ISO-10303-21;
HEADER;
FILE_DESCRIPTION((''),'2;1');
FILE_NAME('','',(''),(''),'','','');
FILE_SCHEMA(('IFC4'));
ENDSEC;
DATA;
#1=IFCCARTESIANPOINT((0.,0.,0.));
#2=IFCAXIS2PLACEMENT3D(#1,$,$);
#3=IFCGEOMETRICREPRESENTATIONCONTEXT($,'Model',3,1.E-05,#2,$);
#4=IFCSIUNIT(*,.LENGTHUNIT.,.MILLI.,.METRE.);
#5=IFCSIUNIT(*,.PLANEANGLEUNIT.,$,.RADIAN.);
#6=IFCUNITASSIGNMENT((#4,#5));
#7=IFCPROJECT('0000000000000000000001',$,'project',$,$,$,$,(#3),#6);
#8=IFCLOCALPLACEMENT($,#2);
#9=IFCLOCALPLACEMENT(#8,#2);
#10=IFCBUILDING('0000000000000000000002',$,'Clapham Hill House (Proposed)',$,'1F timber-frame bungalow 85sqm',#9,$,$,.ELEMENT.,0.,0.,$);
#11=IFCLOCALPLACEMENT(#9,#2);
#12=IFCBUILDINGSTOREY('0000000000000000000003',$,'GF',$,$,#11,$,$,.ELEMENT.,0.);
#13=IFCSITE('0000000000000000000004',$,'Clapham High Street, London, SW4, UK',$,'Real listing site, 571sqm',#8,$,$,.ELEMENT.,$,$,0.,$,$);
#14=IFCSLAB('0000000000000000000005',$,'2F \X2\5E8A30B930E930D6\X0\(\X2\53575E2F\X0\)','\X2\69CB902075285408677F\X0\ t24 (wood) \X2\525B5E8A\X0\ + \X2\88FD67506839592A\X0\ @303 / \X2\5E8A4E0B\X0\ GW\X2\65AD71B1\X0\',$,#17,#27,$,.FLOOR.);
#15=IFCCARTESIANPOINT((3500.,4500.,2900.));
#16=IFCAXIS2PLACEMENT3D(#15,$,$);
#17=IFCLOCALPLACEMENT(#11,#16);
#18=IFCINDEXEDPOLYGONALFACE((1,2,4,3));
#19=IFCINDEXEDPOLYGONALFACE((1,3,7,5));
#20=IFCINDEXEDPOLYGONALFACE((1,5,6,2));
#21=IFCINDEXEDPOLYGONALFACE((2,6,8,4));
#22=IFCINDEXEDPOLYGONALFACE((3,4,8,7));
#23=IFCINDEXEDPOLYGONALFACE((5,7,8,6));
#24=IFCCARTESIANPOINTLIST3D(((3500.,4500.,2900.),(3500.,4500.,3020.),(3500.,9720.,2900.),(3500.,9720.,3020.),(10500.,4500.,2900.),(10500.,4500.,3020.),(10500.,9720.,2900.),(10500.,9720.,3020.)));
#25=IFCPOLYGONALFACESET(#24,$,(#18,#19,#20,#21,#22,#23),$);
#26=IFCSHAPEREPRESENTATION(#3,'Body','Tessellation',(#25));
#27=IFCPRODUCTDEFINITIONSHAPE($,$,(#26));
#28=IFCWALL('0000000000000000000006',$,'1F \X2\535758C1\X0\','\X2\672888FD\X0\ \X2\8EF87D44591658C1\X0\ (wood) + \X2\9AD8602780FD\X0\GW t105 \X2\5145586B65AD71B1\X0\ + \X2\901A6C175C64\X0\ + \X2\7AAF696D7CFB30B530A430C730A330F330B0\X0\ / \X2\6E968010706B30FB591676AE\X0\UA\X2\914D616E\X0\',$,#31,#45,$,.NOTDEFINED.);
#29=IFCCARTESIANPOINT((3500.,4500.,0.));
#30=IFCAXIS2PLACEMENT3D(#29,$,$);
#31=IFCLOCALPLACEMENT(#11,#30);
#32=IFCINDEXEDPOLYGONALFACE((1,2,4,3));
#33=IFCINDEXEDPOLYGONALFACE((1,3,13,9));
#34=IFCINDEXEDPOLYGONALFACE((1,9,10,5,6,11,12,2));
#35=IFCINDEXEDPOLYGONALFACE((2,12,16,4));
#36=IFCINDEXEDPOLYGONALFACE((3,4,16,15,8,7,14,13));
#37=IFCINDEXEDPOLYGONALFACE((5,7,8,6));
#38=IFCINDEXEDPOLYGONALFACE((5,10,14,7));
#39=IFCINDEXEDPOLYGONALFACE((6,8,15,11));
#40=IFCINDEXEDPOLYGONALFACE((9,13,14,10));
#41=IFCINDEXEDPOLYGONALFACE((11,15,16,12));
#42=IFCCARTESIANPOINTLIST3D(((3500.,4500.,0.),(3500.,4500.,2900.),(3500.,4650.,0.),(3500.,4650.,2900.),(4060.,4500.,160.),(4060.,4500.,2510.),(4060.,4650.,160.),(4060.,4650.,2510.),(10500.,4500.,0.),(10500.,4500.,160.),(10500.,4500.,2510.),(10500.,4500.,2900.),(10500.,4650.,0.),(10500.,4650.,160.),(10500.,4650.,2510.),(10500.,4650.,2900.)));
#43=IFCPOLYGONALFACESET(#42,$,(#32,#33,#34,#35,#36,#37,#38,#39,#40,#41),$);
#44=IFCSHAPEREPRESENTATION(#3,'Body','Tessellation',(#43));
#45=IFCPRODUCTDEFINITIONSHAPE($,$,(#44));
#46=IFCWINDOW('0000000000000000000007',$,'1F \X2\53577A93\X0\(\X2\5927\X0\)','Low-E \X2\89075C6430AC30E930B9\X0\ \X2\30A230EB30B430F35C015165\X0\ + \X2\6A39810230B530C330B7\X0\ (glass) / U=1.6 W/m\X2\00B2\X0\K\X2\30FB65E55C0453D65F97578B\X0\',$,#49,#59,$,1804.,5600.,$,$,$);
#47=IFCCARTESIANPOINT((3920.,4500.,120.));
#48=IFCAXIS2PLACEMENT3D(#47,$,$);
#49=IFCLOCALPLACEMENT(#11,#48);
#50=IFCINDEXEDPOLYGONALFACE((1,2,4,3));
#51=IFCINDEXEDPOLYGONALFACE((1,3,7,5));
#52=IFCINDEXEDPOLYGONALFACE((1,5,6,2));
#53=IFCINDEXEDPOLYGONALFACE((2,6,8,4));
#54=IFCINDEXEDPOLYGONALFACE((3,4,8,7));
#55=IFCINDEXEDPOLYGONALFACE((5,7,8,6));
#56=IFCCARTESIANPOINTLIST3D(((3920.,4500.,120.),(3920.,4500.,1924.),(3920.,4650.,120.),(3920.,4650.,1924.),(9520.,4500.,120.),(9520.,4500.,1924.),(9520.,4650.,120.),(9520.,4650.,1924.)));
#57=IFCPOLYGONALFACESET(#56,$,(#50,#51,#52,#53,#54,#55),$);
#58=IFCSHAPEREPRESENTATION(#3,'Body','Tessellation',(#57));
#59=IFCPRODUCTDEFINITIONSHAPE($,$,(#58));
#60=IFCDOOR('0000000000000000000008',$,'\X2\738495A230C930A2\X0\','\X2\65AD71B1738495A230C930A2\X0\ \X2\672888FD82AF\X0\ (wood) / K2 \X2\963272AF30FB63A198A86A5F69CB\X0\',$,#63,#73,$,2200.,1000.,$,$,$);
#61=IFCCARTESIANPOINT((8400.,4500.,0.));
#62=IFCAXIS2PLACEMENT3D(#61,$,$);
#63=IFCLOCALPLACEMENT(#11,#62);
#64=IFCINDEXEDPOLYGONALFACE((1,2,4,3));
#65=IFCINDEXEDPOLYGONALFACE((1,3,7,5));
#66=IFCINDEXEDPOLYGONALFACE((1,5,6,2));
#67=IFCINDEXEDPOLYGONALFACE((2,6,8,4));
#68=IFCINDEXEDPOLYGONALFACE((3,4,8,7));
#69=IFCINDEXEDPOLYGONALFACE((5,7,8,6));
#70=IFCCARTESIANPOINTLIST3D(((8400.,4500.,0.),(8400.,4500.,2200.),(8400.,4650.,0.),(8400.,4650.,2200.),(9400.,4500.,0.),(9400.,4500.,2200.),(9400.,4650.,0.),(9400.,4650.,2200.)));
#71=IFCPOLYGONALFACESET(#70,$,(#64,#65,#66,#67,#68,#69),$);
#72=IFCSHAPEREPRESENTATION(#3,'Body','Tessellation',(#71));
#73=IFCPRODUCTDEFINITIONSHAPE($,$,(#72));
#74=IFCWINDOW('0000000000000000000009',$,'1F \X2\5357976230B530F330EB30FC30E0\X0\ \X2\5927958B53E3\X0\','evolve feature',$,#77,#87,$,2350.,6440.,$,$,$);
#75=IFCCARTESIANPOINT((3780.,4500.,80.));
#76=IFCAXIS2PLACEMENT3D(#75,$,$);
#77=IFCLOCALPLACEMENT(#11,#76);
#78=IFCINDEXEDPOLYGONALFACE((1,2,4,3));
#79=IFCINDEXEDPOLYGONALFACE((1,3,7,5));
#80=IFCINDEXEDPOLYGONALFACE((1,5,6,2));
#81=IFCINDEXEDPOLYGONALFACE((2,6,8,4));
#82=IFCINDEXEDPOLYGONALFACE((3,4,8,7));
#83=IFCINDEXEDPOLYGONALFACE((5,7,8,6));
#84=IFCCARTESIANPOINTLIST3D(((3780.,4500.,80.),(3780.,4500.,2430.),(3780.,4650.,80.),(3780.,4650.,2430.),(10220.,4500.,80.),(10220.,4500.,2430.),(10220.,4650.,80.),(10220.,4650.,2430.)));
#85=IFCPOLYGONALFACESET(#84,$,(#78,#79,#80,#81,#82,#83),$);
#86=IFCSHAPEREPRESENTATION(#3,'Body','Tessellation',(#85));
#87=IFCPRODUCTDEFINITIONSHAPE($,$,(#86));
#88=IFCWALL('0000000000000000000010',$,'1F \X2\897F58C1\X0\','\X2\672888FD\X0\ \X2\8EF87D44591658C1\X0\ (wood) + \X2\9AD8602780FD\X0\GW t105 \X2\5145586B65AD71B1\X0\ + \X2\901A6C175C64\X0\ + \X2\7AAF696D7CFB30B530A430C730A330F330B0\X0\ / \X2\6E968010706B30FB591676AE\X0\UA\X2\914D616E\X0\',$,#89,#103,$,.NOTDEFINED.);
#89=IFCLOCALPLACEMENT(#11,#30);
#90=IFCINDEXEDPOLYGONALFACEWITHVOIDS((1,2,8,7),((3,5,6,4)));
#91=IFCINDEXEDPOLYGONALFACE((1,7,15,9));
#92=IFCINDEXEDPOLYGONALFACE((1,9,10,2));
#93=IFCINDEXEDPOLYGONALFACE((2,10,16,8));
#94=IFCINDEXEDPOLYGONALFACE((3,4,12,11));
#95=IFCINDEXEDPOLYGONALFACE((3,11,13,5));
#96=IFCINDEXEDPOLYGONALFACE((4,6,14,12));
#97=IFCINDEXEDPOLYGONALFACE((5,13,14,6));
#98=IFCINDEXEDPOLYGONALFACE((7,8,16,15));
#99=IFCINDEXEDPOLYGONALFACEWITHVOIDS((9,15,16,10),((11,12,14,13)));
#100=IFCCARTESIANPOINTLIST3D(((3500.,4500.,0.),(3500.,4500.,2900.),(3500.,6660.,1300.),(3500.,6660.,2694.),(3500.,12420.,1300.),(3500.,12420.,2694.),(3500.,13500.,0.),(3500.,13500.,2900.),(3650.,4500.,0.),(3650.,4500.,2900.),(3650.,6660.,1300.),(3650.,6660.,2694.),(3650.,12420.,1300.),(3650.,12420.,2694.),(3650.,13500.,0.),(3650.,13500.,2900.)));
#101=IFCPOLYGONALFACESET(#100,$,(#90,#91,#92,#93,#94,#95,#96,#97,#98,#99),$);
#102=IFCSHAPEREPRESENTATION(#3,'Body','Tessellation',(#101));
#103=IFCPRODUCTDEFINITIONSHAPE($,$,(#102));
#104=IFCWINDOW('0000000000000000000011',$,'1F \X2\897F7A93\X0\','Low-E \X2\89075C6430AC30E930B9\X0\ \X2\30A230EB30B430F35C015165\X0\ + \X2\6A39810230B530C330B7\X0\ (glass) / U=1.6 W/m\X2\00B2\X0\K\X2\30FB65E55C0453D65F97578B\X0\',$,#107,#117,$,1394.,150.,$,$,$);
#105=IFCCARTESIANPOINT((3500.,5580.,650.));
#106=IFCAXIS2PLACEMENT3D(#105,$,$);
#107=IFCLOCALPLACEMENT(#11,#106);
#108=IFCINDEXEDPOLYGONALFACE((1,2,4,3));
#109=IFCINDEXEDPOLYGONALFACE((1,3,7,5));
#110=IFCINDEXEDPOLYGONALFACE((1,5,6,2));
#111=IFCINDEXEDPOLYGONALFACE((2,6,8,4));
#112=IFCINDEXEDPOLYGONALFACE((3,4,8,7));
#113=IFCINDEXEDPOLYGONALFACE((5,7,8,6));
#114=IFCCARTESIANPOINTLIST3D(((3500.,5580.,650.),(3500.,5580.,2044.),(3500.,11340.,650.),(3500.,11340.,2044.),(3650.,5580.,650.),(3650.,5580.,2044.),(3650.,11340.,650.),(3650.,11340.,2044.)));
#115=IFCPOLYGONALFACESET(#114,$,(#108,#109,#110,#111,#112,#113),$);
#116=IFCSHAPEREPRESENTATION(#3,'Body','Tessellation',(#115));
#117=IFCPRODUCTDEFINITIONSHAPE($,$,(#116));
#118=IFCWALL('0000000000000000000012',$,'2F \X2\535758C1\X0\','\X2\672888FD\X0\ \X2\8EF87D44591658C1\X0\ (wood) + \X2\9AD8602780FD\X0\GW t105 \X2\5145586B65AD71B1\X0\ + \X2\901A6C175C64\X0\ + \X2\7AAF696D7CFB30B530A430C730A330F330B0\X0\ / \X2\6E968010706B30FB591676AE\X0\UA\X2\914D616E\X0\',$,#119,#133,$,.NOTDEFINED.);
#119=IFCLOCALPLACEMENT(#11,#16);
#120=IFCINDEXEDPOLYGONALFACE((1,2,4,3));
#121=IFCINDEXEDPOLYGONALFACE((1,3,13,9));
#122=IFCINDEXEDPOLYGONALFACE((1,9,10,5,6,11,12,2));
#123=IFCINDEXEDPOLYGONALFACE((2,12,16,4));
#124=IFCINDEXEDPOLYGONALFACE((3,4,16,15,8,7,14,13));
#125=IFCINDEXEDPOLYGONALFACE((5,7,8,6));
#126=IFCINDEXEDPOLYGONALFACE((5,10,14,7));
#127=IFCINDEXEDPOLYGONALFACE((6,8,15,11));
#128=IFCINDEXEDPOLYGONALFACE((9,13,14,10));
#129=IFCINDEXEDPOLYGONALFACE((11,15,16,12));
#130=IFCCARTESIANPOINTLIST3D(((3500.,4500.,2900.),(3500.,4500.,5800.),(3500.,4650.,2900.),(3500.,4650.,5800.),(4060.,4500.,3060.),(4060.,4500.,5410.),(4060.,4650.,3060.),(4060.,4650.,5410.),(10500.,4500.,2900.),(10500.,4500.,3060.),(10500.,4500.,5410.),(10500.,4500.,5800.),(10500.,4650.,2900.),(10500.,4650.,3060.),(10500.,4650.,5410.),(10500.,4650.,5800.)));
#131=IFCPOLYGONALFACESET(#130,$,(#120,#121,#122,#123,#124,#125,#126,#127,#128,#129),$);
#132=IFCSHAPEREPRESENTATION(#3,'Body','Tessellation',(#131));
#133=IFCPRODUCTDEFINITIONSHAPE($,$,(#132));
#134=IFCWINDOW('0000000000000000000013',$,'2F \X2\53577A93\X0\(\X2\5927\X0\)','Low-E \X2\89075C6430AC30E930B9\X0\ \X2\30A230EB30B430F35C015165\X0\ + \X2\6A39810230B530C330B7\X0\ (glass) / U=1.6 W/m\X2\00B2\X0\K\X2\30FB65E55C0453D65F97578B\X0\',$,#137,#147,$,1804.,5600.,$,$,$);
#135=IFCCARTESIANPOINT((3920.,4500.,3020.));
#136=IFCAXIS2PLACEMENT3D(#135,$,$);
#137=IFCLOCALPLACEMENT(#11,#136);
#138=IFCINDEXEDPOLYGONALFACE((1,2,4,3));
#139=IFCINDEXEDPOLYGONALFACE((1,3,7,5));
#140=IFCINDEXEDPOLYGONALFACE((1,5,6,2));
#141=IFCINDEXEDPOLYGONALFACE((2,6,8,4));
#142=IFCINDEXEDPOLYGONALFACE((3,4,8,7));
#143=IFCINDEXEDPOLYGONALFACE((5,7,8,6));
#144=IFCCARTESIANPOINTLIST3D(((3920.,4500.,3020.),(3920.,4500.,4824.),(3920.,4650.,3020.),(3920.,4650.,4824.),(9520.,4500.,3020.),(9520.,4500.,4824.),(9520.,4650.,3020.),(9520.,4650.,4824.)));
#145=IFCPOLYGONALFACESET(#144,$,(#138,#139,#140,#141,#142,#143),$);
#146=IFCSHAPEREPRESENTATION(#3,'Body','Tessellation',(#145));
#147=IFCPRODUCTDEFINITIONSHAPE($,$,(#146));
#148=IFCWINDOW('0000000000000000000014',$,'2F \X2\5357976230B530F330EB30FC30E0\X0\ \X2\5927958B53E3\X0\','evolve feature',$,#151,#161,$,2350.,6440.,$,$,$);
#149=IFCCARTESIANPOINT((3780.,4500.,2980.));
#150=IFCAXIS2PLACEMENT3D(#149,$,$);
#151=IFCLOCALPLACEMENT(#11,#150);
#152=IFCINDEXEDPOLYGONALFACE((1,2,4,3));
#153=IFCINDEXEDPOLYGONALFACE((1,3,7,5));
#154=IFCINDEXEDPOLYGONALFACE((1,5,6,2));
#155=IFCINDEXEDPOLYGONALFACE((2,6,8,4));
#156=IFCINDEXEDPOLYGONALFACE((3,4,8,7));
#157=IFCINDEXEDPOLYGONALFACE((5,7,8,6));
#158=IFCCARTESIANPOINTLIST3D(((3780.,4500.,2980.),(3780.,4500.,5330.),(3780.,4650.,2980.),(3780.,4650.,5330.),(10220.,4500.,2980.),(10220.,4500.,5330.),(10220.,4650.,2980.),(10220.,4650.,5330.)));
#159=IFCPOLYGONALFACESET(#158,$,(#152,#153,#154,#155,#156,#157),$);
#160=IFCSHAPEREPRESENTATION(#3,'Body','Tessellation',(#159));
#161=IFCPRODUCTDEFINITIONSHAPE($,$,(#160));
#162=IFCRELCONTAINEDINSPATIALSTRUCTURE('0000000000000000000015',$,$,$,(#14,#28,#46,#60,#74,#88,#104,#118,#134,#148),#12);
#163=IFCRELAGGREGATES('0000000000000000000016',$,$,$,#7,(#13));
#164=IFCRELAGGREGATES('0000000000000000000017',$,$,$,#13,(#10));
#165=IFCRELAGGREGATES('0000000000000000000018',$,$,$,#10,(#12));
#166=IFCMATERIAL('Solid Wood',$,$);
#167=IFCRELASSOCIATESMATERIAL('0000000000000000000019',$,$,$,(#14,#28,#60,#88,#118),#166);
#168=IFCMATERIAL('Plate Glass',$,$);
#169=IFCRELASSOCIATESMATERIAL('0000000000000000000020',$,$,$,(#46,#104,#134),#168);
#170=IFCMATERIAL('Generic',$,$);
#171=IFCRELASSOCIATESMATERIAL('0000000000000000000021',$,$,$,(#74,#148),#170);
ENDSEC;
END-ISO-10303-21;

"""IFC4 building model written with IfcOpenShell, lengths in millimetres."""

from ifc_helpers import new_model, si_unit, frame, frame_2d, origin, place, context, project, spatial, rectangle, extrude, material, element, fill, save


model = new_model("IFC4")

# Units and contexts
model_context = context("Model", 3, precision=1e-05, world=origin())
ifc_project = project(units=[si_unit("LENGTHUNIT", "METRE", prefix="MILLI"), si_unit("PLANEANGLEUNIT", "RADIAN")], contexts=[model_context])

# Site, building, storey
site_placement = place(None, origin())
site = spatial("IfcSite", under=ifc_project, at=site_placement, Name="Clapham High Street, London, SW4, UK", ObjectType="Real listing site, 571sqm", CompositionType="ELEMENT", RefElevation=0.0)
building_placement = place(site_placement, origin())
building = spatial("IfcBuilding", under=site, at=building_placement, Name="Clapham Hill House (Proposed)", ObjectType="1F timber-frame bungalow 85sqm", CompositionType="ELEMENT", ElevationOfRefHeight=0.0, ElevationOfTerrain=0.0)
storey_placement = place(building_placement, origin())
storey = spatial("IfcBuildingStorey", under=building, at=storey_placement, Name="GF", CompositionType="ELEMENT", Elevation=0.0)

# Slab
ifc_material_1 = material(Name="Solid Wood")
slab_1_placement = place(storey_placement, frame((3500.0, 4500.0, 2900.0)))
element("IfcSlab", 1, at=slab_1_placement, inside=storey, material=ifc_material_1, Name="2F 床スラブ(南帯)", Description="構造用合板 t24 (wood) 剛床 + 製材根太 @303 / 床下 GW断熱", PredefinedType="FLOOR", context=model_context, shape_type="SweptSolid", body=[
    extrude(rectangle(XDim=7000.0, YDim=5220.0, at=frame_2d((3500.0, 2610.0))), frame((3500.0, 4500.0, 2900.0)), (0.0, 0.0, 1.0), 120.0),
])
ifc_material_2 = material(Name="Generic")

# Wall, openings, windows, door
wall_1_placement = place(storey_placement, frame((3500.0, 4500.0, 0.0)))
wall_1 = element("IfcWall", 2, at=wall_1_placement, inside=storey, material=ifc_material_1, Name="1F 南壁", Description="木製 軸組外壁 (wood) + 高性能GW t105 充填断熱 + 通気層 + 窯業系サイディング / 準耐火・外皮UA配慮", PredefinedType="NOTDEFINED", context=model_context, shape_type="SweptSolid", body=[
    extrude(rectangle(XDim=7000.0, YDim=150.0, at=frame_2d((3500.0, 75.0))), frame((3500.0, 4500.0, 0.0)), (0.0, 0.0, 1.0), 2900.0),
])
opening_1_placement = place(storey_placement, frame((3920.0, 4500.0, 120.0)))
opening_1 = element("IfcOpeningElement", 3, at=opening_1_placement, cuts=wall_1, PredefinedType="NOTDEFINED", context=model_context, shape_type="SweptSolid", body=[
    extrude(rectangle(XDim=5600.0, YDim=150.0, at=frame_2d((2800.0, 75.0))), frame((3920.0, 4500.0, 120.0)), (0.0, 0.0, 1.0), 1804.0),
])
opening_2_placement = place(storey_placement, frame((8400.0, 4500.0, 0.0)))
opening_2 = element("IfcOpeningElement", 4, at=opening_2_placement, cuts=wall_1, PredefinedType="NOTDEFINED", context=model_context, shape_type="SweptSolid", body=[
    extrude(rectangle(XDim=1000.0, YDim=150.0, at=frame_2d((500.0, 75.0))), frame((8400.0, 4500.0, 0.0)), (0.0, 0.0, 1.0), 2200.0),
])
opening_3_placement = place(storey_placement, frame((3780.0, 4500.0, 80.0)))
opening_3 = element("IfcOpeningElement", 5, at=opening_3_placement, cuts=wall_1, PredefinedType="NOTDEFINED", context=model_context, shape_type="SweptSolid", body=[
    extrude(rectangle(XDim=6440.0, YDim=150.0, at=frame_2d((3220.0, 75.0))), frame((3780.0, 4500.0, 80.0)), (0.0, 0.0, 1.0), 2350.0),
])
ifc_material_3 = material(Name="Plate Glass")
window_1_placement = place(storey_placement, frame((3920.0, 4500.0, 120.0)))
window_1 = element("IfcWindow", 6, at=window_1_placement, inside=storey, material=ifc_material_3, Name="1F 南窓(大)", Description="Low-E 複層ガラス アルゴン封入 + 樹脂サッシ (glass) / U=1.6 W/m²K・日射取得型", OverallHeight=1804.0, OverallWidth=5600.0, context=model_context, shape_type="SweptSolid", body=[
    extrude(rectangle(XDim=5600.0, YDim=150.0, at=frame_2d((2800.0, 75.0))), frame((3920.0, 4500.0, 120.0)), (0.0, 0.0, 1.0), 1804.0),
])
fill(opening_1, window_1)
door_placement = place(storey_placement, frame((8400.0, 4500.0, 0.0)))
door = element("IfcDoor", 7, at=door_placement, inside=storey, material=ifc_material_1, Name="玄関ドア", Description="断熱玄関ドア 木製芯 (wood) / K2 防犯・採風機構", OverallHeight=2200.0, OverallWidth=1000.0, context=model_context, shape_type="SweptSolid", body=[
    extrude(rectangle(XDim=1000.0, YDim=150.0, at=frame_2d((500.0, 75.0))), frame((8400.0, 4500.0, 0.0)), (0.0, 0.0, 1.0), 2200.0),
])
fill(opening_2, door)
window_2_placement = place(storey_placement, frame((3780.0, 4500.0, 80.0)))
window_2 = element("IfcWindow", 8, at=window_2_placement, inside=storey, material=ifc_material_2, Name="1F 南面サンルーム 大開口", Description="evolve feature", OverallHeight=2350.0, OverallWidth=6440.0, context=model_context, shape_type="SweptSolid", body=[
    extrude(rectangle(XDim=6440.0, YDim=150.0, at=frame_2d((3220.0, 75.0))), frame((3780.0, 4500.0, 80.0)), (0.0, 0.0, 1.0), 2350.0),
])
fill(opening_3, window_2)

# Wall, opening, window
wall_2_placement = place(storey_placement, frame((3500.0, 4500.0, 0.0)))
wall_2 = element("IfcWall", 9, at=wall_2_placement, inside=storey, material=ifc_material_1, Name="1F 西壁", Description="木製 軸組外壁 (wood) + 高性能GW t105 充填断熱 + 通気層 + 窯業系サイディング / 準耐火・外皮UA配慮", PredefinedType="NOTDEFINED", context=model_context, shape_type="SweptSolid", body=[
    extrude(rectangle(XDim=150.0, YDim=9000.0, at=frame_2d((75.0, 4500.0))), frame((3500.0, 4500.0, 0.0)), (0.0, 0.0, 1.0), 2900.0),
])
opening_4_placement = place(storey_placement, frame((3500.0, 5580.0, 650.0)))
opening_4 = element("IfcOpeningElement", 10, at=opening_4_placement, cuts=wall_2, PredefinedType="NOTDEFINED", context=model_context, shape_type="SweptSolid", body=[
    extrude(rectangle(XDim=150.0, YDim=5760.0, at=frame_2d((75.0, 2880.0))), frame((3500.0, 5580.0, 650.0)), (0.0, 0.0, 1.0), 1394.0),
])
window_3_placement = place(storey_placement, frame((3500.0, 5580.0, 650.0)))
window_3 = element("IfcWindow", 11, at=window_3_placement, inside=storey, material=ifc_material_3, Name="1F 西窓", Description="Low-E 複層ガラス アルゴン封入 + 樹脂サッシ (glass) / U=1.6 W/m²K・日射取得型", OverallHeight=1394.0, OverallWidth=150.0, context=model_context, shape_type="SweptSolid", body=[
    extrude(rectangle(XDim=150.0, YDim=5760.0, at=frame_2d((75.0, 2880.0))), frame((3500.0, 5580.0, 650.0)), (0.0, 0.0, 1.0), 1394.0),
])
fill(opening_4, window_3)

# Wall, openings, windows
wall_3_placement = place(storey_placement, frame((3500.0, 4500.0, 2900.0)))
wall_3 = element("IfcWall", 12, at=wall_3_placement, inside=storey, material=ifc_material_1, Name="2F 南壁", Description="木製 軸組外壁 (wood) + 高性能GW t105 充填断熱 + 通気層 + 窯業系サイディング / 準耐火・外皮UA配慮", PredefinedType="NOTDEFINED", context=model_context, shape_type="SweptSolid", body=[
    extrude(rectangle(XDim=7000.0, YDim=150.0, at=frame_2d((3500.0, 75.0))), frame((3500.0, 4500.0, 2900.0)), (0.0, 0.0, 1.0), 2900.0),
])
opening_5_placement = place(storey_placement, frame((3920.0, 4500.0, 3020.0)))
opening_5 = element("IfcOpeningElement", 13, at=opening_5_placement, cuts=wall_3, PredefinedType="NOTDEFINED", context=model_context, shape_type="SweptSolid", body=[
    extrude(rectangle(XDim=5600.0, YDim=150.0, at=frame_2d((2800.0, 75.0))), frame((3920.0, 4500.0, 3020.0)), (0.0, 0.0, 1.0), 1804.0),
])
opening_6_placement = place(storey_placement, frame((3780.0, 4500.0, 2980.0)))
opening_6 = element("IfcOpeningElement", 14, at=opening_6_placement, cuts=wall_3, PredefinedType="NOTDEFINED", context=model_context, shape_type="SweptSolid", body=[
    extrude(rectangle(XDim=6440.0, YDim=150.0, at=frame_2d((3220.0, 75.0))), frame((3780.0, 4500.0, 2980.0)), (0.0, 0.0, 1.0), 2350.0),
])
window_4_placement = place(storey_placement, frame((3920.0, 4500.0, 3020.0)))
window_4 = element("IfcWindow", 15, at=window_4_placement, inside=storey, material=ifc_material_3, Name="2F 南窓(大)", Description="Low-E 複層ガラス アルゴン封入 + 樹脂サッシ (glass) / U=1.6 W/m²K・日射取得型", OverallHeight=1804.0, OverallWidth=5600.0, context=model_context, shape_type="SweptSolid", body=[
    extrude(rectangle(XDim=5600.0, YDim=150.0, at=frame_2d((2800.0, 75.0))), frame((3920.0, 4500.0, 3020.0)), (0.0, 0.0, 1.0), 1804.0),
])
fill(opening_5, window_4)
window_5_placement = place(storey_placement, frame((3780.0, 4500.0, 2980.0)))
window_5 = element("IfcWindow", 16, at=window_5_placement, inside=storey, material=ifc_material_2, Name="2F 南面サンルーム 大開口", Description="evolve feature", OverallHeight=2350.0, OverallWidth=6440.0, context=model_context, shape_type="SweptSolid", body=[
    extrude(rectangle(XDim=6440.0, YDim=150.0, at=frame_2d((3220.0, 75.0))), frame((3780.0, 4500.0, 2980.0)), (0.0, 0.0, 1.0), 2350.0),
])
fill(opening_6, window_5)

save(model, "model.ifc")
